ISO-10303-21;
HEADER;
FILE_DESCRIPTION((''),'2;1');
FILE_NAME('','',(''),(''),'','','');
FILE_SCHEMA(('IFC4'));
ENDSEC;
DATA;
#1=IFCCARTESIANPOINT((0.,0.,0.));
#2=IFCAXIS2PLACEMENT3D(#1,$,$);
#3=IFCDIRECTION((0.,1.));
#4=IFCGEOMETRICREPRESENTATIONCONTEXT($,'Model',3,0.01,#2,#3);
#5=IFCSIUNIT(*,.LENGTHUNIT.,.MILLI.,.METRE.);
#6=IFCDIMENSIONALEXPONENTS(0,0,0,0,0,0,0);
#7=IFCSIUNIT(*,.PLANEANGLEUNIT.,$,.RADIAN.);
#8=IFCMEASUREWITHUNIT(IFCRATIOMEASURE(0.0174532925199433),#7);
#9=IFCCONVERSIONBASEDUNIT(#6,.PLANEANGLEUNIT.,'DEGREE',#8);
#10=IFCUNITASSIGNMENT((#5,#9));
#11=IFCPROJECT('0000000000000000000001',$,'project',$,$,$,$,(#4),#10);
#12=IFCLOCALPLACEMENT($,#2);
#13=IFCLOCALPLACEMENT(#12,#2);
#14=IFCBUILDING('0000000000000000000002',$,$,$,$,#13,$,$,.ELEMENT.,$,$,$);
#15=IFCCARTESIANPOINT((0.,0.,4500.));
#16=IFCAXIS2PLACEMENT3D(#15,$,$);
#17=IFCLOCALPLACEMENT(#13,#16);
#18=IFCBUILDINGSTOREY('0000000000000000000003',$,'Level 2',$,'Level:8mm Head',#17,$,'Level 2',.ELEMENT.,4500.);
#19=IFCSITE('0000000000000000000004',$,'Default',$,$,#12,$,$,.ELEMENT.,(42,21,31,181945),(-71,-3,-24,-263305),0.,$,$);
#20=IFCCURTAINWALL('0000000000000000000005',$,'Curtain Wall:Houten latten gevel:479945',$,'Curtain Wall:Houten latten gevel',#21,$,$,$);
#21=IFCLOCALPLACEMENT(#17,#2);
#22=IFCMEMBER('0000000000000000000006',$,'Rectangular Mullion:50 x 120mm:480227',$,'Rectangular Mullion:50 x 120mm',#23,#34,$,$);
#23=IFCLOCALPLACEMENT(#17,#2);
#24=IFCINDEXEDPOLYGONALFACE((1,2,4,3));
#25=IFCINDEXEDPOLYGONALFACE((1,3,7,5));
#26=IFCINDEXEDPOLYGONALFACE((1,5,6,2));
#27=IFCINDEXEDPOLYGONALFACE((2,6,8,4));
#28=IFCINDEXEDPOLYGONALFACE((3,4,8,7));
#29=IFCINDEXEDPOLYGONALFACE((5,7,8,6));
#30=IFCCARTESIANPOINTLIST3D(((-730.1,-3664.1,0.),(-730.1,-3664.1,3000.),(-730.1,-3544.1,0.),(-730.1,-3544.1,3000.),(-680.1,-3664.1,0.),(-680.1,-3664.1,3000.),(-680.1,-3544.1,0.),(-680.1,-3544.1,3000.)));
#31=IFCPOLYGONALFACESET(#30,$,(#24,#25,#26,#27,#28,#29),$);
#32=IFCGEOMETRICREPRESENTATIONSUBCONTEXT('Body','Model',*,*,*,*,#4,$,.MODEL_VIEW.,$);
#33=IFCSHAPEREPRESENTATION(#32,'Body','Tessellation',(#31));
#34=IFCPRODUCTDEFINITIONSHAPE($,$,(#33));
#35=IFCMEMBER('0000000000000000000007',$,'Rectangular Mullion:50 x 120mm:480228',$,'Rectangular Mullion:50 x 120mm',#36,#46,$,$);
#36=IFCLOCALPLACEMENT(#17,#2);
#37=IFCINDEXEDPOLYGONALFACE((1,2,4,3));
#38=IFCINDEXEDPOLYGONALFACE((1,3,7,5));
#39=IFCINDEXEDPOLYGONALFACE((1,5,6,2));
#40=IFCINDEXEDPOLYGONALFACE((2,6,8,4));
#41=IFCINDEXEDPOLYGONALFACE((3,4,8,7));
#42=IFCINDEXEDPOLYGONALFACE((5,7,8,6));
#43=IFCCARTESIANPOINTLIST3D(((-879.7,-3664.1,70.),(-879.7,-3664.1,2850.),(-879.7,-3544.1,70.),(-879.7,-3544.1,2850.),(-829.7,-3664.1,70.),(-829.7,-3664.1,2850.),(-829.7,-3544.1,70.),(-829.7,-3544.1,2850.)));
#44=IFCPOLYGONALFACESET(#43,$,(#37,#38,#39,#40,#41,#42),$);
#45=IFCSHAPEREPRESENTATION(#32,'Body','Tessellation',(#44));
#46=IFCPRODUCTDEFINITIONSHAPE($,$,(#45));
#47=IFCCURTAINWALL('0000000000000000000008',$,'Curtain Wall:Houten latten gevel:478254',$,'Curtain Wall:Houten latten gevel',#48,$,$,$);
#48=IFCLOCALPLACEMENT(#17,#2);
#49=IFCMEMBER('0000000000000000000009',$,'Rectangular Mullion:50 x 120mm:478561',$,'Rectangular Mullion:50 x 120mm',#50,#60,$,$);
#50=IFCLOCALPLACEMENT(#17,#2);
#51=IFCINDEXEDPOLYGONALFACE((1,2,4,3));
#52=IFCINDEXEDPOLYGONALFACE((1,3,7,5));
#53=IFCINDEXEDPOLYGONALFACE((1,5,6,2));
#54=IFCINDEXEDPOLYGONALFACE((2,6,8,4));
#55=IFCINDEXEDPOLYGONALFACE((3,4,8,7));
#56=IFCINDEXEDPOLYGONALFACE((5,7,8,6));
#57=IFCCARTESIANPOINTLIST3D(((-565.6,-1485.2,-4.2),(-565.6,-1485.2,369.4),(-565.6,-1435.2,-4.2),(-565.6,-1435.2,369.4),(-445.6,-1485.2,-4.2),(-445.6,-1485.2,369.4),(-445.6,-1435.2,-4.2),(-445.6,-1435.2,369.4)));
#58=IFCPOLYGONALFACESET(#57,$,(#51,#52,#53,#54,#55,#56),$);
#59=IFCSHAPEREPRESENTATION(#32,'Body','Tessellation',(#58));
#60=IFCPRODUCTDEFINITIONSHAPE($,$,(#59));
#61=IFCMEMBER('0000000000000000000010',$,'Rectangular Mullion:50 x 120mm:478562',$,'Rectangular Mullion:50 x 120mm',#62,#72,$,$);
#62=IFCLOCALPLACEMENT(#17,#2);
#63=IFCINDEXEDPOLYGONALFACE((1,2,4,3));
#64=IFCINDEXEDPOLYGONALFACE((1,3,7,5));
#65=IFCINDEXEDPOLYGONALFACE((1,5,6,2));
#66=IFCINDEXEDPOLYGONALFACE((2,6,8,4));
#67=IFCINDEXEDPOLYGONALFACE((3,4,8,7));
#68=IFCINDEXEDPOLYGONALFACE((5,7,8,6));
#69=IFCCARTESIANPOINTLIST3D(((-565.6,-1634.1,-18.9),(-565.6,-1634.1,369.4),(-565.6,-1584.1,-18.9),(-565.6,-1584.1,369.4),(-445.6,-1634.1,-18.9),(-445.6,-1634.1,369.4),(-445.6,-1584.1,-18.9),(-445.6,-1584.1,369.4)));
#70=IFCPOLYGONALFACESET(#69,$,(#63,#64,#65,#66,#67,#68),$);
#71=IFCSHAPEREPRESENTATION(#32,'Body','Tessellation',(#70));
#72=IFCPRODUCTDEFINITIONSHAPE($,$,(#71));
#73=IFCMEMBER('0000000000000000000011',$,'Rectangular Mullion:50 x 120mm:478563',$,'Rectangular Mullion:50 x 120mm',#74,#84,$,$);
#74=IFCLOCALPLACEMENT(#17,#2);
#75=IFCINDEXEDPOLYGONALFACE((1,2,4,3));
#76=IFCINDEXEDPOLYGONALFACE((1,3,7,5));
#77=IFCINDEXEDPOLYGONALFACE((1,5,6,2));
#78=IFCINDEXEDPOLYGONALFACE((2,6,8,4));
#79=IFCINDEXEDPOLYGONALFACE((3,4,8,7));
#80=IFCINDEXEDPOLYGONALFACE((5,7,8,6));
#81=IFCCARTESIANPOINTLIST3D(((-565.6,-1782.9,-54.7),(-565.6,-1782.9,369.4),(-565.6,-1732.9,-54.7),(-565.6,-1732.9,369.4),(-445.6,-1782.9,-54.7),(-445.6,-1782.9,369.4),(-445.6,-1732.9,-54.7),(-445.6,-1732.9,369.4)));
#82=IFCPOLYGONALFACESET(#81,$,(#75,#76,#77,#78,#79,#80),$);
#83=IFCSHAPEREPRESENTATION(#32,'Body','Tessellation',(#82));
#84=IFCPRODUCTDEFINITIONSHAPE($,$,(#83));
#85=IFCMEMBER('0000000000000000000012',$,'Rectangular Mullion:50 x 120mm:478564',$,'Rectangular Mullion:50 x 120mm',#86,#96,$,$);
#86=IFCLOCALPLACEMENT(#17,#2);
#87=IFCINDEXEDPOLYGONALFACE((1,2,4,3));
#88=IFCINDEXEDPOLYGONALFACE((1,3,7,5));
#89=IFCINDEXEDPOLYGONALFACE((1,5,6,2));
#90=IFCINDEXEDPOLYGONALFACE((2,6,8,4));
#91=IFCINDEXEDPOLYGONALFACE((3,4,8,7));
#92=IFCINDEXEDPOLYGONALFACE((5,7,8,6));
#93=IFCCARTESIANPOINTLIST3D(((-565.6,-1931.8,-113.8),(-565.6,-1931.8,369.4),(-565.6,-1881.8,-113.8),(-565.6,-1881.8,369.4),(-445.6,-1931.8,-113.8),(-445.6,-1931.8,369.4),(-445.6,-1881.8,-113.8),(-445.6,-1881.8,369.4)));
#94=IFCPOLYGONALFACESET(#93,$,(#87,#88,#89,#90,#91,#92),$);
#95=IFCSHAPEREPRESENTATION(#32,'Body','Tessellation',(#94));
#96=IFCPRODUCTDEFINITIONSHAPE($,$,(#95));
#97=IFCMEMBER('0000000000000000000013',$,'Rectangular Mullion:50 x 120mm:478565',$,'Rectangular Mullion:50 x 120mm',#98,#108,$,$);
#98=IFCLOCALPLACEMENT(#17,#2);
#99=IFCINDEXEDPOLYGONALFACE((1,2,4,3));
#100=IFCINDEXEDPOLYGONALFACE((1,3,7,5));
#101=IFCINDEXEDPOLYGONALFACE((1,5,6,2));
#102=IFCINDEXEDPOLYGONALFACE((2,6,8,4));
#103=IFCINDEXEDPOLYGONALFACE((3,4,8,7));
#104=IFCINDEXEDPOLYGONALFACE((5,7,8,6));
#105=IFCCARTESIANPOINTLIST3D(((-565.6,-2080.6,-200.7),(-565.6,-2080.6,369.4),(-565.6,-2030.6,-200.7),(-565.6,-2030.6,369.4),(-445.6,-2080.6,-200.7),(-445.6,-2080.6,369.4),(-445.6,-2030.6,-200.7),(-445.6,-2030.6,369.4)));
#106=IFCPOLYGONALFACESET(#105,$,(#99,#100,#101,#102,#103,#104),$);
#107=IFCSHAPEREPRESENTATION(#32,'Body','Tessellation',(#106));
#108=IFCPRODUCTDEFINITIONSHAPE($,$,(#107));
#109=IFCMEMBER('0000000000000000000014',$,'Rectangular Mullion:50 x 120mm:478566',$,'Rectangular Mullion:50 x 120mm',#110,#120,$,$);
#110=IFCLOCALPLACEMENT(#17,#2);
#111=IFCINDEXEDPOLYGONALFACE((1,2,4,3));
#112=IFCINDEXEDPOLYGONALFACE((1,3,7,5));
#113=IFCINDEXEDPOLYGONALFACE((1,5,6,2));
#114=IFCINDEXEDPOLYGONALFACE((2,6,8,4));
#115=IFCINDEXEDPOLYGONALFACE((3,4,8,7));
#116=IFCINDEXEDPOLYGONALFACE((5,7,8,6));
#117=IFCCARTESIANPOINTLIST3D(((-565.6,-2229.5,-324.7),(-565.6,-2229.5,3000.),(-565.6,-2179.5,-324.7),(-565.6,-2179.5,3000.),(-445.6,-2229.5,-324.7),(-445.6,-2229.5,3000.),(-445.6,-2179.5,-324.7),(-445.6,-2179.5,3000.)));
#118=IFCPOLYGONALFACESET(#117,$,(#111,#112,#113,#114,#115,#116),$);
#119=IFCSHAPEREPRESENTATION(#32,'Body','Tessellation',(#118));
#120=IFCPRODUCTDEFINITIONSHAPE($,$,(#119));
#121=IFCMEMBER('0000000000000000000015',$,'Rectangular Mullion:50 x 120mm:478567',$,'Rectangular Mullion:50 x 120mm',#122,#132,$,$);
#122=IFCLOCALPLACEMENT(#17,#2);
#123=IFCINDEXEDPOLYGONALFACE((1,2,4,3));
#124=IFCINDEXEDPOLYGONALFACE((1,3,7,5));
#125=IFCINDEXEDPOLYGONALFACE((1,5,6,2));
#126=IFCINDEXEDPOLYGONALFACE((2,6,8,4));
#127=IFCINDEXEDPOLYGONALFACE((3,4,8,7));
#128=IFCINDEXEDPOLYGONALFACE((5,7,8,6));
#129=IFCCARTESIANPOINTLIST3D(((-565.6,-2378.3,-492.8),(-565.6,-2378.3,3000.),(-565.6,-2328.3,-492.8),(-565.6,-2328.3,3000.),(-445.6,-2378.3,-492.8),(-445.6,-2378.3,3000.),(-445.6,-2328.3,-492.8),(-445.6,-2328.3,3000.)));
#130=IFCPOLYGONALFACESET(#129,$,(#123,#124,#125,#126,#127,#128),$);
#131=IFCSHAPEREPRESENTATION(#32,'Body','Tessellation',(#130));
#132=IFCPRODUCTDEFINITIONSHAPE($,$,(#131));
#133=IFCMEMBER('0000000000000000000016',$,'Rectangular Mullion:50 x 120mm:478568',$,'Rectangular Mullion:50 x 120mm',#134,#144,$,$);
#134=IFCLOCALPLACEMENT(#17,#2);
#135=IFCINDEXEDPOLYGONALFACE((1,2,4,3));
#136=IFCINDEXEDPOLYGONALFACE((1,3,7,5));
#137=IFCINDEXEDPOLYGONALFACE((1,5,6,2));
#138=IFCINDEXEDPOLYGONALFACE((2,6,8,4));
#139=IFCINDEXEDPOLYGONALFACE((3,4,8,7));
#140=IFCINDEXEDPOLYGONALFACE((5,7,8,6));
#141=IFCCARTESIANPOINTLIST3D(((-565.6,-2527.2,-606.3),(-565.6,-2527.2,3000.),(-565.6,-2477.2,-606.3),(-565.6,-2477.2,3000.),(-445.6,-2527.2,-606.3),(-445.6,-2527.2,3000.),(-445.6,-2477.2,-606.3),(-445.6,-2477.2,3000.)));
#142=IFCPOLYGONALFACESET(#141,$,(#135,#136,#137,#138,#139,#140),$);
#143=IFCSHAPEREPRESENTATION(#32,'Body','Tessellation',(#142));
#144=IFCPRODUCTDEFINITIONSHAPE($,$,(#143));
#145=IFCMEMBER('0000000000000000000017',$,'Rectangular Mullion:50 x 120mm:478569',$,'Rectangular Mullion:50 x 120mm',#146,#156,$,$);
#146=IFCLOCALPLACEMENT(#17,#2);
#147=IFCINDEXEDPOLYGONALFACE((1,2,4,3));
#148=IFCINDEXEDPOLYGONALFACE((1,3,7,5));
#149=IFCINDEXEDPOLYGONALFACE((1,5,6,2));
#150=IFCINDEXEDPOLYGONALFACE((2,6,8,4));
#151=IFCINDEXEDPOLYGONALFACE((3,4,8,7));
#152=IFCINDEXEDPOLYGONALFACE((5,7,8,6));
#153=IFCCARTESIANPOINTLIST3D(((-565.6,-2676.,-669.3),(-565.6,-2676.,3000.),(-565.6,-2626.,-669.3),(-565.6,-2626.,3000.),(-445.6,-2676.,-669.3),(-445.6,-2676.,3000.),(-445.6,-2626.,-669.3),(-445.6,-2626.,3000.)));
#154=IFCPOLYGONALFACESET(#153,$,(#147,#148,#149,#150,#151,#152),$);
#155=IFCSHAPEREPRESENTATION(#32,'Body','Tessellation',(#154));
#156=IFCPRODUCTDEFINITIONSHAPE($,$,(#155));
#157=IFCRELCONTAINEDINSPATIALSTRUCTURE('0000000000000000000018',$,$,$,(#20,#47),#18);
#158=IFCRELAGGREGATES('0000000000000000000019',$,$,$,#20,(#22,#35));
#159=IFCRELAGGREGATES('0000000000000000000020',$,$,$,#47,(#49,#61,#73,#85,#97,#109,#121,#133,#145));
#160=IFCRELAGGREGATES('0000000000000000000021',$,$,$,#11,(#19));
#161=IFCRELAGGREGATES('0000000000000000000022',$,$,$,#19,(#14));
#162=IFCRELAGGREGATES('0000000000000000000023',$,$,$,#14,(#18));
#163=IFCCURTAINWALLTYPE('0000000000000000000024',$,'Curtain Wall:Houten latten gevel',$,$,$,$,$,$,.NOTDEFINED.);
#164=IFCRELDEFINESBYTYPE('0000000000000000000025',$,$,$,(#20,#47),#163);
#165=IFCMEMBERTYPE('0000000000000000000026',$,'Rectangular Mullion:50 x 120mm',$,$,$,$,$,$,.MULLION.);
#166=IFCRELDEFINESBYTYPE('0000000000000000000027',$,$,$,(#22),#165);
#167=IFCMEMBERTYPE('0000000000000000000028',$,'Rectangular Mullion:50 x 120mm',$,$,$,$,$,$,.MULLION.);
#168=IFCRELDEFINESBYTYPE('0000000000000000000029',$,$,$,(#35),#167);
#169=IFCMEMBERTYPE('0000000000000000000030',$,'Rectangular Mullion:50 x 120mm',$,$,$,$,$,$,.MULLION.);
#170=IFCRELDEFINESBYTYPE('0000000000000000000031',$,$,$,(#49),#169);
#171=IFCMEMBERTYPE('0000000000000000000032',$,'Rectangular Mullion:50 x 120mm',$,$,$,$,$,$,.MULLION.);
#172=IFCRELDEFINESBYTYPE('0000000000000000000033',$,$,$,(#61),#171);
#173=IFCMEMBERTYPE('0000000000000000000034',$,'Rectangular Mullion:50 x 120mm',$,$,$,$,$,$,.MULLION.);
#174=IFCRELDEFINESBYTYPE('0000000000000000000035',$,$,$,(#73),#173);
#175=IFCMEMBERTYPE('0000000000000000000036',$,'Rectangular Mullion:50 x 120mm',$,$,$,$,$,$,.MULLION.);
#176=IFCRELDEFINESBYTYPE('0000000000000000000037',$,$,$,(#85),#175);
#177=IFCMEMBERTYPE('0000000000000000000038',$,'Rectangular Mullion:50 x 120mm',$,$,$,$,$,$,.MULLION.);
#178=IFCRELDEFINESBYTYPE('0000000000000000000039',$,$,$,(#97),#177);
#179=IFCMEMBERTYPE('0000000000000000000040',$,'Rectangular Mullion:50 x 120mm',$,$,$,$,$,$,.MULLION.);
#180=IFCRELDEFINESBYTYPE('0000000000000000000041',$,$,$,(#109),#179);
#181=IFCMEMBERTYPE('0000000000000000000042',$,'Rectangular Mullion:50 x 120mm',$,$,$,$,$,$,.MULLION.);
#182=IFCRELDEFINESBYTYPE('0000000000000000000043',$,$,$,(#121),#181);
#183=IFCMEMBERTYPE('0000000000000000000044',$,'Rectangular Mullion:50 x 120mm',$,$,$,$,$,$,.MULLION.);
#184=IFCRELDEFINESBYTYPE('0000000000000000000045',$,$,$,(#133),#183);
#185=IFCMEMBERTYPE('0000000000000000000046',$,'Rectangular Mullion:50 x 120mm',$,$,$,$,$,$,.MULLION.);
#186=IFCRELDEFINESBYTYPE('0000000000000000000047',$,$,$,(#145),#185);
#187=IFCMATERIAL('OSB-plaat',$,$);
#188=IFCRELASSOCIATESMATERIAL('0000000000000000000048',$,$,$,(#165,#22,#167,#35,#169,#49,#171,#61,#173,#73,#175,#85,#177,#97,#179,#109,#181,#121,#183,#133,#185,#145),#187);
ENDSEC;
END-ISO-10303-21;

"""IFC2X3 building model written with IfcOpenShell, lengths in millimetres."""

from ifc_helpers import new_model, entity, si_unit, converted_unit, direction, frame, origin, origin_2d_with_axis, place, context, subcontext, project, spatial, rectangle, extrude, source, transform, mapped, material, type_object, type_shapes, element, aggregate, save


model = new_model("IFC2X3")

# Units and contexts
model_context = context("Model", 3, precision=0.01, world=origin(), true_north=direction((0.0, 1.0)))
body_context = subcontext(model_context, "Body", "Model", "MODEL_VIEW")
ifc_project = project(units=[si_unit("LENGTHUNIT", "METRE", prefix="MILLI"), converted_unit("PLANEANGLEUNIT", "DEGREE", entity("IfcRatioMeasure", 0.0174532925199433), si_unit("PLANEANGLEUNIT", "RADIAN"), dimensions=[0, 0, 0, 0, 0, 0, 0])], contexts=[model_context])

# Site, building, storey
site_placement = place(None, frame((0.0, 0.0, 0.0)))
site = spatial("IfcSite", under=ifc_project, at=site_placement, Name="Default", CompositionType="ELEMENT", RefLatitude=(42, 21, 31, 181945), RefLongitude=(-71, -3, -24, -263305), RefElevation=0.0)
building_placement = place(site_placement, origin())
building = spatial("IfcBuilding", under=site, at=building_placement, CompositionType="ELEMENT")
storey_placement = place(building_placement, frame((0.0, 0.0, 4500.0)))
storey = spatial("IfcBuildingStorey", under=building, at=storey_placement, Name="Level 2", ObjectType="Level:8mm Head", LongName="Level 2", CompositionType="ELEMENT", Elevation=4500.0)

# Curtain walls, members
curtain_wall_type = type_object("IfcCurtainWallType", Name="Curtain Wall:Houten latten gevel", PredefinedType="NOTDEFINED")
curtain_wall_1_placement = place(storey_placement, frame((0.0, 0.0, -4500.0)))
curtain_wall_1 = element("IfcCurtainWall", 1, at=curtain_wall_1_placement, inside=storey, type_object=curtain_wall_type, Name="Curtain Wall:Houten latten gevel:479945", ObjectType="Curtain Wall:Houten latten gevel")
ifc_material_1 = material(Name="OSB-plaat")
member_type_1 = type_object("IfcMemberType", Name="Rectangular Mullion:50 x 120mm", PredefinedType="MULLION", material=ifc_material_1)
shared_shape_1 = source(origin(), body_context, "Body", "SweptSolid", [
    extrude(rectangle(XDim=120.0, YDim=50.0, at=origin_2d_with_axis()), frame((0.0, 0.0, -3000.0), z_axis=(0.0, 0.0, 1.0), x_axis=(0.0, -1.0, 0.0)), (0.0, 0.0, 1.0), 3000.0),
])
type_shapes(member_type_1, [shared_shape_1])
member_1_placement = place(storey_placement, frame((-705.1, -3604.1, 0.0), z_axis=(0.0, 0.0, -1.0), x_axis=(-1.0, 0.0, 0.0)))
member_1 = element("IfcMember", 2, at=member_1_placement, type_object=member_type_1, material=ifc_material_1, Name="Rectangular Mullion:50 x 120mm:480227", ObjectType="Rectangular Mullion:50 x 120mm", context=body_context, shape_type="MappedRepresentation", body=[
    mapped(shared_shape_1, transform((0.0, 0.0, 0.0), scale=1.0)),
])
member_type_2 = type_object("IfcMemberType", Name="Rectangular Mullion:50 x 120mm", PredefinedType="MULLION", material=ifc_material_1)
shared_shape_2 = source(origin(), body_context, "Body", "SweptSolid", [
    extrude(rectangle(XDim=120.0, YDim=50.0, at=origin_2d_with_axis()), frame((0.0, 0.0, -2780.0), z_axis=(0.0, 0.0, 1.0), x_axis=(0.0, -1.0, 0.0)), (0.0, 0.0, 1.0), 2780.0),
])
type_shapes(member_type_2, [shared_shape_2])
member_2_placement = place(storey_placement, frame((-854.7, -3604.1, 70.0), z_axis=(0.0, 0.0, -1.0), x_axis=(-1.0, 0.0, 0.0)))
member_2 = element("IfcMember", 3, at=member_2_placement, type_object=member_type_2, material=ifc_material_1, Name="Rectangular Mullion:50 x 120mm:480228", ObjectType="Rectangular Mullion:50 x 120mm", context=body_context, shape_type="MappedRepresentation", body=[
    mapped(shared_shape_2, transform((0.0, 0.0, 0.0), scale=1.0)),
])
aggregate(curtain_wall_1, [member_1, member_2])
curtain_wall_2_placement = place(storey_placement, frame((0.0, 0.0, -4500.0)))
curtain_wall_2 = element("IfcCurtainWall", 4, at=curtain_wall_2_placement, inside=storey, type_object=curtain_wall_type, Name="Curtain Wall:Houten latten gevel:478254", ObjectType="Curtain Wall:Houten latten gevel")
member_type_3 = type_object("IfcMemberType", Name="Rectangular Mullion:50 x 120mm", PredefinedType="MULLION", material=ifc_material_1)
shared_shape_3 = source(origin(), body_context, "Body", "SweptSolid", [
    extrude(rectangle(XDim=120.0, YDim=50.0, at=origin_2d_with_axis()), frame((0.0, 0.0, -373.5), z_axis=(0.0, 0.0, 1.0), x_axis=(0.0, -1.0, 0.0)), (0.0, 0.0, 1.0), 373.5),
])
type_shapes(member_type_3, [shared_shape_3])
member_3_placement = place(storey_placement, frame((-505.6, -1460.2, -4.2), z_axis=(0.0, 0.0, -1.0), x_axis=(0.0, -1.0, 0.0)))
member_3 = element("IfcMember", 5, at=member_3_placement, type_object=member_type_3, material=ifc_material_1, Name="Rectangular Mullion:50 x 120mm:478561", ObjectType="Rectangular Mullion:50 x 120mm", context=body_context, shape_type="MappedRepresentation", body=[
    mapped(shared_shape_3, transform((0.0, 0.0, 0.0), scale=1.0)),
])
member_type_4 = type_object("IfcMemberType", Name="Rectangular Mullion:50 x 120mm", PredefinedType="MULLION", material=ifc_material_1)
shared_shape_4 = source(origin(), body_context, "Body", "SweptSolid", [
    extrude(rectangle(XDim=120.0, YDim=50.0, at=origin_2d_with_axis()), frame((0.0, 0.0, -388.3), z_axis=(0.0, 0.0, 1.0), x_axis=(0.0, -1.0, 0.0)), (0.0, 0.0, 1.0), 388.3),
])
type_shapes(member_type_4, [shared_shape_4])
member_4_placement = place(storey_placement, frame((-505.6, -1609.1, -18.9), z_axis=(0.0, 0.0, -1.0), x_axis=(0.0, -1.0, 0.0)))
member_4 = element("IfcMember", 6, at=member_4_placement, type_object=member_type_4, material=ifc_material_1, Name="Rectangular Mullion:50 x 120mm:478562", ObjectType="Rectangular Mullion:50 x 120mm", context=body_context, shape_type="MappedRepresentation", body=[
    mapped(shared_shape_4, transform((0.0, 0.0, 0.0), scale=1.0)),
])
member_type_5 = type_object("IfcMemberType", Name="Rectangular Mullion:50 x 120mm", PredefinedType="MULLION", material=ifc_material_1)
shared_shape_5 = source(origin(), body_context, "Body", "SweptSolid", [
    extrude(rectangle(XDim=120.0, YDim=50.0, at=origin_2d_with_axis()), frame((0.0, 0.0, -424.1), z_axis=(0.0, 0.0, 1.0), x_axis=(0.0, -1.0, 0.0)), (0.0, 0.0, 1.0), 424.1),
])
type_shapes(member_type_5, [shared_shape_5])
member_5_placement = place(storey_placement, frame((-505.6, -1757.9, -54.7), z_axis=(0.0, 0.0, -1.0), x_axis=(0.0, -1.0, 0.0)))
member_5 = element("IfcMember", 7, at=member_5_placement, type_object=member_type_5, material=ifc_material_1, Name="Rectangular Mullion:50 x 120mm:478563", ObjectType="Rectangular Mullion:50 x 120mm", context=body_context, shape_type="MappedRepresentation", body=[
    mapped(shared_shape_5, transform((0.0, 0.0, 0.0), scale=1.0)),
])
member_type_6 = type_object("IfcMemberType", Name="Rectangular Mullion:50 x 120mm", PredefinedType="MULLION", material=ifc_material_1)
shared_shape_6 = source(origin(), body_context, "Body", "SweptSolid", [
    extrude(rectangle(XDim=120.0, YDim=50.0, at=origin_2d_with_axis()), frame((0.0, 0.0, -483.2), z_axis=(0.0, 0.0, 1.0), x_axis=(0.0, -1.0, 0.0)), (0.0, 0.0, 1.0), 483.2),
])
type_shapes(member_type_6, [shared_shape_6])
member_6_placement = place(storey_placement, frame((-505.6, -1906.8, -113.8), z_axis=(0.0, 0.0, -1.0), x_axis=(0.0, -1.0, 0.0)))
member_6 = element("IfcMember", 8, at=member_6_placement, type_object=member_type_6, material=ifc_material_1, Name="Rectangular Mullion:50 x 120mm:478564", ObjectType="Rectangular Mullion:50 x 120mm", context=body_context, shape_type="MappedRepresentation", body=[
    mapped(shared_shape_6, transform((0.0, 0.0, 0.0), scale=1.0)),
])
member_type_7 = type_object("IfcMemberType", Name="Rectangular Mullion:50 x 120mm", PredefinedType="MULLION", material=ifc_material_1)
shared_shape_7 = source(origin(), body_context, "Body", "SweptSolid", [
    extrude(rectangle(XDim=120.0, YDim=50.0, at=origin_2d_with_axis()), frame((0.0, 0.0, -570.1), z_axis=(0.0, 0.0, 1.0), x_axis=(0.0, -1.0, 0.0)), (0.0, 0.0, 1.0), 570.1),
])
type_shapes(member_type_7, [shared_shape_7])
member_7_placement = place(storey_placement, frame((-505.6, -2055.6, -200.7), z_axis=(0.0, 0.0, -1.0), x_axis=(0.0, -1.0, 0.0)))
member_7 = element("IfcMember", 9, at=member_7_placement, type_object=member_type_7, material=ifc_material_1, Name="Rectangular Mullion:50 x 120mm:478565", ObjectType="Rectangular Mullion:50 x 120mm", context=body_context, shape_type="MappedRepresentation", body=[
    mapped(shared_shape_7, transform((0.0, 0.0, 0.0), scale=1.0)),
])
member_type_8 = type_object("IfcMemberType", Name="Rectangular Mullion:50 x 120mm", PredefinedType="MULLION", material=ifc_material_1)
shared_shape_8 = source(origin(), body_context, "Body", "SweptSolid", [
    extrude(rectangle(XDim=120.0, YDim=50.0, at=origin_2d_with_axis()), frame((0.0, 0.0, -3324.7), z_axis=(0.0, 0.0, 1.0), x_axis=(0.0, -1.0, 0.0)), (0.0, 0.0, 1.0), 3324.7),
])
type_shapes(member_type_8, [shared_shape_8])
member_8_placement = place(storey_placement, frame((-505.6, -2204.5, -324.7), z_axis=(0.0, 0.0, -1.0), x_axis=(0.0, -1.0, 0.0)))
member_8 = element("IfcMember", 10, at=member_8_placement, type_object=member_type_8, material=ifc_material_1, Name="Rectangular Mullion:50 x 120mm:478566", ObjectType="Rectangular Mullion:50 x 120mm", context=body_context, shape_type="MappedRepresentation", body=[
    mapped(shared_shape_8, transform((0.0, 0.0, 0.0), scale=1.0)),
])
member_type_9 = type_object("IfcMemberType", Name="Rectangular Mullion:50 x 120mm", PredefinedType="MULLION", material=ifc_material_1)
shared_shape_9 = source(origin(), body_context, "Body", "SweptSolid", [
    extrude(rectangle(XDim=120.0, YDim=50.0, at=origin_2d_with_axis()), frame((0.0, 0.0, -3492.8), z_axis=(0.0, 0.0, 1.0), x_axis=(0.0, -1.0, 0.0)), (0.0, 0.0, 1.0), 3492.8),
])
type_shapes(member_type_9, [shared_shape_9])
member_9_placement = place(storey_placement, frame((-505.6, -2353.3, -492.8), z_axis=(0.0, 0.0, -1.0), x_axis=(0.0, -1.0, 0.0)))
member_9 = element("IfcMember", 11, at=member_9_placement, type_object=member_type_9, material=ifc_material_1, Name="Rectangular Mullion:50 x 120mm:478567", ObjectType="Rectangular Mullion:50 x 120mm", context=body_context, shape_type="MappedRepresentation", body=[
    mapped(shared_shape_9, transform((0.0, 0.0, 0.0), scale=1.0)),
])
member_type_10 = type_object("IfcMemberType", Name="Rectangular Mullion:50 x 120mm", PredefinedType="MULLION", material=ifc_material_1)
shared_shape_10 = source(origin(), body_context, "Body", "SweptSolid", [
    extrude(rectangle(XDim=120.0, YDim=50.0, at=origin_2d_with_axis()), frame((0.0, 0.0, -3606.3), z_axis=(0.0, 0.0, 1.0), x_axis=(0.0, -1.0, 0.0)), (0.0, 0.0, 1.0), 3606.3),
])
type_shapes(member_type_10, [shared_shape_10])
member_10_placement = place(storey_placement, frame((-505.6, -2502.2, -606.3), z_axis=(0.0, 0.0, -1.0), x_axis=(0.0, -1.0, 0.0)))
member_10 = element("IfcMember", 12, at=member_10_placement, type_object=member_type_10, material=ifc_material_1, Name="Rectangular Mullion:50 x 120mm:478568", ObjectType="Rectangular Mullion:50 x 120mm", context=body_context, shape_type="MappedRepresentation", body=[
    mapped(shared_shape_10, transform((0.0, 0.0, 0.0), scale=1.0)),
])
member_type_11 = type_object("IfcMemberType", Name="Rectangular Mullion:50 x 120mm", PredefinedType="MULLION", material=ifc_material_1)
shared_shape_11 = source(origin(), body_context, "Body", "SweptSolid", [
    extrude(rectangle(XDim=120.0, YDim=50.0, at=origin_2d_with_axis()), frame((0.0, 0.0, -3669.3), z_axis=(0.0, 0.0, 1.0), x_axis=(0.0, -1.0, 0.0)), (0.0, 0.0, 1.0), 3669.3),
])
type_shapes(member_type_11, [shared_shape_11])
member_11_placement = place(storey_placement, frame((-505.6, -2651.0, -669.3), z_axis=(0.0, 0.0, -1.0), x_axis=(0.0, -1.0, 0.0)))
member_11 = element("IfcMember", 13, at=member_11_placement, type_object=member_type_11, material=ifc_material_1, Name="Rectangular Mullion:50 x 120mm:478569", ObjectType="Rectangular Mullion:50 x 120mm", context=body_context, shape_type="MappedRepresentation", body=[
    mapped(shared_shape_11, transform((0.0, 0.0, 0.0), scale=1.0)),
])
aggregate(curtain_wall_2, [member_3, member_4, member_5, member_6, member_7, member_8, member_9, member_10, member_11])

save(model, "model.ifc")
